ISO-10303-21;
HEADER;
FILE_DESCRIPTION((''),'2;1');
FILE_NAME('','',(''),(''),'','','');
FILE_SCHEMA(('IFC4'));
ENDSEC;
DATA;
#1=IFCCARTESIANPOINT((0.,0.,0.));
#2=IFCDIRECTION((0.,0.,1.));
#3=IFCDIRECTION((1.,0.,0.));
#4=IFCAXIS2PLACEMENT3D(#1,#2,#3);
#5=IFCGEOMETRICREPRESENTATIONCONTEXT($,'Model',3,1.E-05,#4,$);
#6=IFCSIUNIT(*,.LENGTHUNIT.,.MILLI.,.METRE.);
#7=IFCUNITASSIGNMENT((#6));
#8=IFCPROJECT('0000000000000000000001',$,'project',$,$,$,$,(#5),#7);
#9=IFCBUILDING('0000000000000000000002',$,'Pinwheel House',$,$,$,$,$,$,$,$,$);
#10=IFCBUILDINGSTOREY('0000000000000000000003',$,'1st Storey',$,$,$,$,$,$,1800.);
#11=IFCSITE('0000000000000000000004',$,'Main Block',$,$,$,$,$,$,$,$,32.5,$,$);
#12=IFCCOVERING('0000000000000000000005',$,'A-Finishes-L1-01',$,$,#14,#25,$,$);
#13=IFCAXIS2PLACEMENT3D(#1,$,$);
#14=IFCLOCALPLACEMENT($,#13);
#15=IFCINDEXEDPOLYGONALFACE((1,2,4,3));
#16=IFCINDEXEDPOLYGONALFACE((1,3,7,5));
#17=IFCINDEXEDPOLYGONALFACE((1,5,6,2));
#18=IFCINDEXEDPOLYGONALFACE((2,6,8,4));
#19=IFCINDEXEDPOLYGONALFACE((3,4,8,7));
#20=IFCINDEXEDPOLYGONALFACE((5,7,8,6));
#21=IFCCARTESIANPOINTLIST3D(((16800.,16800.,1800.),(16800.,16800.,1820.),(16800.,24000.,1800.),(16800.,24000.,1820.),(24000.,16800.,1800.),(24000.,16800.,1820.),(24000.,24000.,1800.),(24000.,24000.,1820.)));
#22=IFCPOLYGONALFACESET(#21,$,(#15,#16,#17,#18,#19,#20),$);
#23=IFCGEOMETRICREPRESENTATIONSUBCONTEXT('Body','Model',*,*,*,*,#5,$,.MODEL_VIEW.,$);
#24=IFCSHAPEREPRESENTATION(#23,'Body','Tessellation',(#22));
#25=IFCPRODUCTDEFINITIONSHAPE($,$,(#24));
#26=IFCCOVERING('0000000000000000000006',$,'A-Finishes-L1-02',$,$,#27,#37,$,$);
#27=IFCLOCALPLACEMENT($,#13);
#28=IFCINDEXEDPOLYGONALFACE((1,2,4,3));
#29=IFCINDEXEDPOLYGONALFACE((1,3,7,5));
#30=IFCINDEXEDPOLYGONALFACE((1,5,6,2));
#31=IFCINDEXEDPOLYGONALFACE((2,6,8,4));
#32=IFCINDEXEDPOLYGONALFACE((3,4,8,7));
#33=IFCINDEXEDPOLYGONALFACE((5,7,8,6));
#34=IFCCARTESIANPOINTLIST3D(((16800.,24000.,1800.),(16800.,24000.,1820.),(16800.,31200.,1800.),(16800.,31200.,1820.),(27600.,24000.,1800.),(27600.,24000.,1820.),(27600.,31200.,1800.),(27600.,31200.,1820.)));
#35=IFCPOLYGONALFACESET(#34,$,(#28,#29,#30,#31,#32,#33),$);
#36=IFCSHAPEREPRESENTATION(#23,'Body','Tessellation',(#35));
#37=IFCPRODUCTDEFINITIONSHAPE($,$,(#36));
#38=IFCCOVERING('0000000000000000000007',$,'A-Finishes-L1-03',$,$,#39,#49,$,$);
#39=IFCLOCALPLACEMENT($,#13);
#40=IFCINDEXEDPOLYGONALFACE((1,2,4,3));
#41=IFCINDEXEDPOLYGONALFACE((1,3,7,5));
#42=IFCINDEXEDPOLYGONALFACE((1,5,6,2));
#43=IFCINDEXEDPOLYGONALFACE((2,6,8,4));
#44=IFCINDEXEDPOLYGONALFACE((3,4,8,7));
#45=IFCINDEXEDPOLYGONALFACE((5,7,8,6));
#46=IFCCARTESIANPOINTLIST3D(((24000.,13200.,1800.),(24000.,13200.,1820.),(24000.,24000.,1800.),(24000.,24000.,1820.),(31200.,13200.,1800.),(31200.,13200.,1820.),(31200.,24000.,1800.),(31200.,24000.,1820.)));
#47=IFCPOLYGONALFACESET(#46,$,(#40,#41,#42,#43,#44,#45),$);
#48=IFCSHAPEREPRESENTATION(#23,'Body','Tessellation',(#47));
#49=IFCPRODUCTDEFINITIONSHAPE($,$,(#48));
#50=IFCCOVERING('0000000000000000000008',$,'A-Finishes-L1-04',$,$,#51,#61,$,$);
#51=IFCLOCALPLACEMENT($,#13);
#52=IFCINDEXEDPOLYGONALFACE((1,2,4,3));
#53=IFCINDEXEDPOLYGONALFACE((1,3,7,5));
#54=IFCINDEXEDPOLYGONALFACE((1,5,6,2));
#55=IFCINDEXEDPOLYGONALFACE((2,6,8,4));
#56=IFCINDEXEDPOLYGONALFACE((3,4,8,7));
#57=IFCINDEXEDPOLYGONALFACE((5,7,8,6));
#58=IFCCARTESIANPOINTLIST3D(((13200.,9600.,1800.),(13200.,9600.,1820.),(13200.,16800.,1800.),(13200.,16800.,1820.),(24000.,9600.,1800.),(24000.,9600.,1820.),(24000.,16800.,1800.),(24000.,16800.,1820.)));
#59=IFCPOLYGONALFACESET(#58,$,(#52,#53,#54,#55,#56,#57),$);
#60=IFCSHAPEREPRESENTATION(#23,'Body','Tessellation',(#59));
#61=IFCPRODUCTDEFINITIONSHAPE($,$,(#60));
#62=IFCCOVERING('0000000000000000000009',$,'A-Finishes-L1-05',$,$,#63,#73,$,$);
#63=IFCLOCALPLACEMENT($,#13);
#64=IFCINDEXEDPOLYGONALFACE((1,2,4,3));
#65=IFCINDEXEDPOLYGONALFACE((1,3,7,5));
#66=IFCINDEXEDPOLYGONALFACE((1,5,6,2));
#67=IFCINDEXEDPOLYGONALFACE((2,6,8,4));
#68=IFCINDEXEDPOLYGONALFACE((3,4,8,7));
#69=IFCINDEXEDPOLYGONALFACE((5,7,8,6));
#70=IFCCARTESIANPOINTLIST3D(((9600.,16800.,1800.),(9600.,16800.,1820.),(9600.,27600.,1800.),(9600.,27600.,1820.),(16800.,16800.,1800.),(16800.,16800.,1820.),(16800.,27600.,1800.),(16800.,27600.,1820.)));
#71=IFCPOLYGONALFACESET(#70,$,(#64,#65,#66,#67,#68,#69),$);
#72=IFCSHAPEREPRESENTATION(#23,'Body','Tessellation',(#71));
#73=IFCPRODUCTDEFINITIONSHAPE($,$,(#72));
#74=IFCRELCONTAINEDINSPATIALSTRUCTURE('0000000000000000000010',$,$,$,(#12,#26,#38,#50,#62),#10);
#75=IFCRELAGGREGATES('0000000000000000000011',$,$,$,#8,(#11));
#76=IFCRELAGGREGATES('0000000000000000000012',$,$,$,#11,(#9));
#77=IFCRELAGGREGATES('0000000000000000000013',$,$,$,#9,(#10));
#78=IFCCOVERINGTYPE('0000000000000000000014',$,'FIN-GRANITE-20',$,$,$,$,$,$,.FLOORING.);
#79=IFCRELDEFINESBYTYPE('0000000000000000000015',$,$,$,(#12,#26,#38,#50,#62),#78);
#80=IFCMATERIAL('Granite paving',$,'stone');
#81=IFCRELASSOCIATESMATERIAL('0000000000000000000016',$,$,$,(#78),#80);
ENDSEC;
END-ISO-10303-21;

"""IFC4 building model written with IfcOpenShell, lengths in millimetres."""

from ifc_helpers import new_model, si_unit, frame, origin_with_axes, place, context, subcontext, project, spatial, indexed_curve, outline, extrude, material, type_object, element, save


model = new_model("IFC4")

# Units and contexts
model_context = context("Model", 3, precision=1e-05, world=origin_with_axes())
body_context = subcontext(model_context, "Body", "Model", "MODEL_VIEW")
ifc_project = project(units=[si_unit("LENGTHUNIT", "METRE", prefix="MILLI")], contexts=[model_context])

# Site, building, storey
site = spatial("IfcSite", under=ifc_project, Name="Main Block", RefElevation=32.5)
building = spatial("IfcBuilding", under=site, Name="Pinwheel House")
storey = spatial("IfcBuildingStorey", under=building, Name="1st Storey", Elevation=1800.0)

# Coverings
ifc_material_1 = material(Name="Granite paving", Category="stone")
covering_type = type_object("IfcCoveringType", Name="FIN-GRANITE-20", PredefinedType="FLOORING", material=ifc_material_1)
covering_1_placement = place(None, frame((0.0, 0.0, 1800.0), z_axis=(0.0, 0.0, 1.0), x_axis=(1.0, 0.0, 0.0)))
element("IfcCovering", 1, at=covering_1_placement, inside=storey, type_object=covering_type, Name="A-Finishes-L1-01", context=body_context, shape_type="SweptSolid", body=[
    extrude(outline(indexed_curve([(16800.0, 16800.0), (24000.0, 16800.0), (24000.0, 24000.0), (16800.0, 24000.0)])), None, (0.0, 0.0, 1.0), 20.0),
])
covering_2_placement = place(None, frame((0.0, 0.0, 1800.0), z_axis=(0.0, 0.0, 1.0), x_axis=(1.0, 0.0, 0.0)))
element("IfcCovering", 2, at=covering_2_placement, inside=storey, type_object=covering_type, Name="A-Finishes-L1-02", context=body_context, shape_type="SweptSolid", body=[
    extrude(outline(indexed_curve([(16800.0, 24000.0), (27600.0, 24000.0), (27600.0, 31200.0), (16800.0, 31200.0)])), None, (0.0, 0.0, 1.0), 20.0),
])
covering_3_placement = place(None, frame((0.0, 0.0, 1800.0), z_axis=(0.0, 0.0, 1.0), x_axis=(1.0, 0.0, 0.0)))
element("IfcCovering", 3, at=covering_3_placement, inside=storey, type_object=covering_type, Name="A-Finishes-L1-03", context=body_context, shape_type="SweptSolid", body=[
    extrude(outline(indexed_curve([(24000.0, 13200.0), (31200.0, 13200.0), (31200.0, 24000.0), (24000.0, 24000.0)])), None, (0.0, 0.0, 1.0), 20.0),
])
covering_4_placement = place(None, frame((0.0, 0.0, 1800.0), z_axis=(0.0, 0.0, 1.0), x_axis=(1.0, 0.0, 0.0)))
element("IfcCovering", 4, at=covering_4_placement, inside=storey, type_object=covering_type, Name="A-Finishes-L1-04", context=body_context, shape_type="SweptSolid", body=[
    extrude(outline(indexed_curve([(13200.0, 9600.0), (24000.0, 9600.0), (24000.0, 16800.0), (13200.0, 16800.0)])), None, (0.0, 0.0, 1.0), 20.0),
])
covering_5_placement = place(None, frame((0.0, 0.0, 1800.0), z_axis=(0.0, 0.0, 1.0), x_axis=(1.0, 0.0, 0.0)))
element("IfcCovering", 5, at=covering_5_placement, inside=storey, type_object=covering_type, Name="A-Finishes-L1-05", context=body_context, shape_type="SweptSolid", body=[
    extrude(outline(indexed_curve([(9600.0, 16800.0), (16800.0, 16800.0), (16800.0, 27600.0), (9600.0, 27600.0)])), None, (0.0, 0.0, 1.0), 20.0),
])

save(model, "model.ifc")
